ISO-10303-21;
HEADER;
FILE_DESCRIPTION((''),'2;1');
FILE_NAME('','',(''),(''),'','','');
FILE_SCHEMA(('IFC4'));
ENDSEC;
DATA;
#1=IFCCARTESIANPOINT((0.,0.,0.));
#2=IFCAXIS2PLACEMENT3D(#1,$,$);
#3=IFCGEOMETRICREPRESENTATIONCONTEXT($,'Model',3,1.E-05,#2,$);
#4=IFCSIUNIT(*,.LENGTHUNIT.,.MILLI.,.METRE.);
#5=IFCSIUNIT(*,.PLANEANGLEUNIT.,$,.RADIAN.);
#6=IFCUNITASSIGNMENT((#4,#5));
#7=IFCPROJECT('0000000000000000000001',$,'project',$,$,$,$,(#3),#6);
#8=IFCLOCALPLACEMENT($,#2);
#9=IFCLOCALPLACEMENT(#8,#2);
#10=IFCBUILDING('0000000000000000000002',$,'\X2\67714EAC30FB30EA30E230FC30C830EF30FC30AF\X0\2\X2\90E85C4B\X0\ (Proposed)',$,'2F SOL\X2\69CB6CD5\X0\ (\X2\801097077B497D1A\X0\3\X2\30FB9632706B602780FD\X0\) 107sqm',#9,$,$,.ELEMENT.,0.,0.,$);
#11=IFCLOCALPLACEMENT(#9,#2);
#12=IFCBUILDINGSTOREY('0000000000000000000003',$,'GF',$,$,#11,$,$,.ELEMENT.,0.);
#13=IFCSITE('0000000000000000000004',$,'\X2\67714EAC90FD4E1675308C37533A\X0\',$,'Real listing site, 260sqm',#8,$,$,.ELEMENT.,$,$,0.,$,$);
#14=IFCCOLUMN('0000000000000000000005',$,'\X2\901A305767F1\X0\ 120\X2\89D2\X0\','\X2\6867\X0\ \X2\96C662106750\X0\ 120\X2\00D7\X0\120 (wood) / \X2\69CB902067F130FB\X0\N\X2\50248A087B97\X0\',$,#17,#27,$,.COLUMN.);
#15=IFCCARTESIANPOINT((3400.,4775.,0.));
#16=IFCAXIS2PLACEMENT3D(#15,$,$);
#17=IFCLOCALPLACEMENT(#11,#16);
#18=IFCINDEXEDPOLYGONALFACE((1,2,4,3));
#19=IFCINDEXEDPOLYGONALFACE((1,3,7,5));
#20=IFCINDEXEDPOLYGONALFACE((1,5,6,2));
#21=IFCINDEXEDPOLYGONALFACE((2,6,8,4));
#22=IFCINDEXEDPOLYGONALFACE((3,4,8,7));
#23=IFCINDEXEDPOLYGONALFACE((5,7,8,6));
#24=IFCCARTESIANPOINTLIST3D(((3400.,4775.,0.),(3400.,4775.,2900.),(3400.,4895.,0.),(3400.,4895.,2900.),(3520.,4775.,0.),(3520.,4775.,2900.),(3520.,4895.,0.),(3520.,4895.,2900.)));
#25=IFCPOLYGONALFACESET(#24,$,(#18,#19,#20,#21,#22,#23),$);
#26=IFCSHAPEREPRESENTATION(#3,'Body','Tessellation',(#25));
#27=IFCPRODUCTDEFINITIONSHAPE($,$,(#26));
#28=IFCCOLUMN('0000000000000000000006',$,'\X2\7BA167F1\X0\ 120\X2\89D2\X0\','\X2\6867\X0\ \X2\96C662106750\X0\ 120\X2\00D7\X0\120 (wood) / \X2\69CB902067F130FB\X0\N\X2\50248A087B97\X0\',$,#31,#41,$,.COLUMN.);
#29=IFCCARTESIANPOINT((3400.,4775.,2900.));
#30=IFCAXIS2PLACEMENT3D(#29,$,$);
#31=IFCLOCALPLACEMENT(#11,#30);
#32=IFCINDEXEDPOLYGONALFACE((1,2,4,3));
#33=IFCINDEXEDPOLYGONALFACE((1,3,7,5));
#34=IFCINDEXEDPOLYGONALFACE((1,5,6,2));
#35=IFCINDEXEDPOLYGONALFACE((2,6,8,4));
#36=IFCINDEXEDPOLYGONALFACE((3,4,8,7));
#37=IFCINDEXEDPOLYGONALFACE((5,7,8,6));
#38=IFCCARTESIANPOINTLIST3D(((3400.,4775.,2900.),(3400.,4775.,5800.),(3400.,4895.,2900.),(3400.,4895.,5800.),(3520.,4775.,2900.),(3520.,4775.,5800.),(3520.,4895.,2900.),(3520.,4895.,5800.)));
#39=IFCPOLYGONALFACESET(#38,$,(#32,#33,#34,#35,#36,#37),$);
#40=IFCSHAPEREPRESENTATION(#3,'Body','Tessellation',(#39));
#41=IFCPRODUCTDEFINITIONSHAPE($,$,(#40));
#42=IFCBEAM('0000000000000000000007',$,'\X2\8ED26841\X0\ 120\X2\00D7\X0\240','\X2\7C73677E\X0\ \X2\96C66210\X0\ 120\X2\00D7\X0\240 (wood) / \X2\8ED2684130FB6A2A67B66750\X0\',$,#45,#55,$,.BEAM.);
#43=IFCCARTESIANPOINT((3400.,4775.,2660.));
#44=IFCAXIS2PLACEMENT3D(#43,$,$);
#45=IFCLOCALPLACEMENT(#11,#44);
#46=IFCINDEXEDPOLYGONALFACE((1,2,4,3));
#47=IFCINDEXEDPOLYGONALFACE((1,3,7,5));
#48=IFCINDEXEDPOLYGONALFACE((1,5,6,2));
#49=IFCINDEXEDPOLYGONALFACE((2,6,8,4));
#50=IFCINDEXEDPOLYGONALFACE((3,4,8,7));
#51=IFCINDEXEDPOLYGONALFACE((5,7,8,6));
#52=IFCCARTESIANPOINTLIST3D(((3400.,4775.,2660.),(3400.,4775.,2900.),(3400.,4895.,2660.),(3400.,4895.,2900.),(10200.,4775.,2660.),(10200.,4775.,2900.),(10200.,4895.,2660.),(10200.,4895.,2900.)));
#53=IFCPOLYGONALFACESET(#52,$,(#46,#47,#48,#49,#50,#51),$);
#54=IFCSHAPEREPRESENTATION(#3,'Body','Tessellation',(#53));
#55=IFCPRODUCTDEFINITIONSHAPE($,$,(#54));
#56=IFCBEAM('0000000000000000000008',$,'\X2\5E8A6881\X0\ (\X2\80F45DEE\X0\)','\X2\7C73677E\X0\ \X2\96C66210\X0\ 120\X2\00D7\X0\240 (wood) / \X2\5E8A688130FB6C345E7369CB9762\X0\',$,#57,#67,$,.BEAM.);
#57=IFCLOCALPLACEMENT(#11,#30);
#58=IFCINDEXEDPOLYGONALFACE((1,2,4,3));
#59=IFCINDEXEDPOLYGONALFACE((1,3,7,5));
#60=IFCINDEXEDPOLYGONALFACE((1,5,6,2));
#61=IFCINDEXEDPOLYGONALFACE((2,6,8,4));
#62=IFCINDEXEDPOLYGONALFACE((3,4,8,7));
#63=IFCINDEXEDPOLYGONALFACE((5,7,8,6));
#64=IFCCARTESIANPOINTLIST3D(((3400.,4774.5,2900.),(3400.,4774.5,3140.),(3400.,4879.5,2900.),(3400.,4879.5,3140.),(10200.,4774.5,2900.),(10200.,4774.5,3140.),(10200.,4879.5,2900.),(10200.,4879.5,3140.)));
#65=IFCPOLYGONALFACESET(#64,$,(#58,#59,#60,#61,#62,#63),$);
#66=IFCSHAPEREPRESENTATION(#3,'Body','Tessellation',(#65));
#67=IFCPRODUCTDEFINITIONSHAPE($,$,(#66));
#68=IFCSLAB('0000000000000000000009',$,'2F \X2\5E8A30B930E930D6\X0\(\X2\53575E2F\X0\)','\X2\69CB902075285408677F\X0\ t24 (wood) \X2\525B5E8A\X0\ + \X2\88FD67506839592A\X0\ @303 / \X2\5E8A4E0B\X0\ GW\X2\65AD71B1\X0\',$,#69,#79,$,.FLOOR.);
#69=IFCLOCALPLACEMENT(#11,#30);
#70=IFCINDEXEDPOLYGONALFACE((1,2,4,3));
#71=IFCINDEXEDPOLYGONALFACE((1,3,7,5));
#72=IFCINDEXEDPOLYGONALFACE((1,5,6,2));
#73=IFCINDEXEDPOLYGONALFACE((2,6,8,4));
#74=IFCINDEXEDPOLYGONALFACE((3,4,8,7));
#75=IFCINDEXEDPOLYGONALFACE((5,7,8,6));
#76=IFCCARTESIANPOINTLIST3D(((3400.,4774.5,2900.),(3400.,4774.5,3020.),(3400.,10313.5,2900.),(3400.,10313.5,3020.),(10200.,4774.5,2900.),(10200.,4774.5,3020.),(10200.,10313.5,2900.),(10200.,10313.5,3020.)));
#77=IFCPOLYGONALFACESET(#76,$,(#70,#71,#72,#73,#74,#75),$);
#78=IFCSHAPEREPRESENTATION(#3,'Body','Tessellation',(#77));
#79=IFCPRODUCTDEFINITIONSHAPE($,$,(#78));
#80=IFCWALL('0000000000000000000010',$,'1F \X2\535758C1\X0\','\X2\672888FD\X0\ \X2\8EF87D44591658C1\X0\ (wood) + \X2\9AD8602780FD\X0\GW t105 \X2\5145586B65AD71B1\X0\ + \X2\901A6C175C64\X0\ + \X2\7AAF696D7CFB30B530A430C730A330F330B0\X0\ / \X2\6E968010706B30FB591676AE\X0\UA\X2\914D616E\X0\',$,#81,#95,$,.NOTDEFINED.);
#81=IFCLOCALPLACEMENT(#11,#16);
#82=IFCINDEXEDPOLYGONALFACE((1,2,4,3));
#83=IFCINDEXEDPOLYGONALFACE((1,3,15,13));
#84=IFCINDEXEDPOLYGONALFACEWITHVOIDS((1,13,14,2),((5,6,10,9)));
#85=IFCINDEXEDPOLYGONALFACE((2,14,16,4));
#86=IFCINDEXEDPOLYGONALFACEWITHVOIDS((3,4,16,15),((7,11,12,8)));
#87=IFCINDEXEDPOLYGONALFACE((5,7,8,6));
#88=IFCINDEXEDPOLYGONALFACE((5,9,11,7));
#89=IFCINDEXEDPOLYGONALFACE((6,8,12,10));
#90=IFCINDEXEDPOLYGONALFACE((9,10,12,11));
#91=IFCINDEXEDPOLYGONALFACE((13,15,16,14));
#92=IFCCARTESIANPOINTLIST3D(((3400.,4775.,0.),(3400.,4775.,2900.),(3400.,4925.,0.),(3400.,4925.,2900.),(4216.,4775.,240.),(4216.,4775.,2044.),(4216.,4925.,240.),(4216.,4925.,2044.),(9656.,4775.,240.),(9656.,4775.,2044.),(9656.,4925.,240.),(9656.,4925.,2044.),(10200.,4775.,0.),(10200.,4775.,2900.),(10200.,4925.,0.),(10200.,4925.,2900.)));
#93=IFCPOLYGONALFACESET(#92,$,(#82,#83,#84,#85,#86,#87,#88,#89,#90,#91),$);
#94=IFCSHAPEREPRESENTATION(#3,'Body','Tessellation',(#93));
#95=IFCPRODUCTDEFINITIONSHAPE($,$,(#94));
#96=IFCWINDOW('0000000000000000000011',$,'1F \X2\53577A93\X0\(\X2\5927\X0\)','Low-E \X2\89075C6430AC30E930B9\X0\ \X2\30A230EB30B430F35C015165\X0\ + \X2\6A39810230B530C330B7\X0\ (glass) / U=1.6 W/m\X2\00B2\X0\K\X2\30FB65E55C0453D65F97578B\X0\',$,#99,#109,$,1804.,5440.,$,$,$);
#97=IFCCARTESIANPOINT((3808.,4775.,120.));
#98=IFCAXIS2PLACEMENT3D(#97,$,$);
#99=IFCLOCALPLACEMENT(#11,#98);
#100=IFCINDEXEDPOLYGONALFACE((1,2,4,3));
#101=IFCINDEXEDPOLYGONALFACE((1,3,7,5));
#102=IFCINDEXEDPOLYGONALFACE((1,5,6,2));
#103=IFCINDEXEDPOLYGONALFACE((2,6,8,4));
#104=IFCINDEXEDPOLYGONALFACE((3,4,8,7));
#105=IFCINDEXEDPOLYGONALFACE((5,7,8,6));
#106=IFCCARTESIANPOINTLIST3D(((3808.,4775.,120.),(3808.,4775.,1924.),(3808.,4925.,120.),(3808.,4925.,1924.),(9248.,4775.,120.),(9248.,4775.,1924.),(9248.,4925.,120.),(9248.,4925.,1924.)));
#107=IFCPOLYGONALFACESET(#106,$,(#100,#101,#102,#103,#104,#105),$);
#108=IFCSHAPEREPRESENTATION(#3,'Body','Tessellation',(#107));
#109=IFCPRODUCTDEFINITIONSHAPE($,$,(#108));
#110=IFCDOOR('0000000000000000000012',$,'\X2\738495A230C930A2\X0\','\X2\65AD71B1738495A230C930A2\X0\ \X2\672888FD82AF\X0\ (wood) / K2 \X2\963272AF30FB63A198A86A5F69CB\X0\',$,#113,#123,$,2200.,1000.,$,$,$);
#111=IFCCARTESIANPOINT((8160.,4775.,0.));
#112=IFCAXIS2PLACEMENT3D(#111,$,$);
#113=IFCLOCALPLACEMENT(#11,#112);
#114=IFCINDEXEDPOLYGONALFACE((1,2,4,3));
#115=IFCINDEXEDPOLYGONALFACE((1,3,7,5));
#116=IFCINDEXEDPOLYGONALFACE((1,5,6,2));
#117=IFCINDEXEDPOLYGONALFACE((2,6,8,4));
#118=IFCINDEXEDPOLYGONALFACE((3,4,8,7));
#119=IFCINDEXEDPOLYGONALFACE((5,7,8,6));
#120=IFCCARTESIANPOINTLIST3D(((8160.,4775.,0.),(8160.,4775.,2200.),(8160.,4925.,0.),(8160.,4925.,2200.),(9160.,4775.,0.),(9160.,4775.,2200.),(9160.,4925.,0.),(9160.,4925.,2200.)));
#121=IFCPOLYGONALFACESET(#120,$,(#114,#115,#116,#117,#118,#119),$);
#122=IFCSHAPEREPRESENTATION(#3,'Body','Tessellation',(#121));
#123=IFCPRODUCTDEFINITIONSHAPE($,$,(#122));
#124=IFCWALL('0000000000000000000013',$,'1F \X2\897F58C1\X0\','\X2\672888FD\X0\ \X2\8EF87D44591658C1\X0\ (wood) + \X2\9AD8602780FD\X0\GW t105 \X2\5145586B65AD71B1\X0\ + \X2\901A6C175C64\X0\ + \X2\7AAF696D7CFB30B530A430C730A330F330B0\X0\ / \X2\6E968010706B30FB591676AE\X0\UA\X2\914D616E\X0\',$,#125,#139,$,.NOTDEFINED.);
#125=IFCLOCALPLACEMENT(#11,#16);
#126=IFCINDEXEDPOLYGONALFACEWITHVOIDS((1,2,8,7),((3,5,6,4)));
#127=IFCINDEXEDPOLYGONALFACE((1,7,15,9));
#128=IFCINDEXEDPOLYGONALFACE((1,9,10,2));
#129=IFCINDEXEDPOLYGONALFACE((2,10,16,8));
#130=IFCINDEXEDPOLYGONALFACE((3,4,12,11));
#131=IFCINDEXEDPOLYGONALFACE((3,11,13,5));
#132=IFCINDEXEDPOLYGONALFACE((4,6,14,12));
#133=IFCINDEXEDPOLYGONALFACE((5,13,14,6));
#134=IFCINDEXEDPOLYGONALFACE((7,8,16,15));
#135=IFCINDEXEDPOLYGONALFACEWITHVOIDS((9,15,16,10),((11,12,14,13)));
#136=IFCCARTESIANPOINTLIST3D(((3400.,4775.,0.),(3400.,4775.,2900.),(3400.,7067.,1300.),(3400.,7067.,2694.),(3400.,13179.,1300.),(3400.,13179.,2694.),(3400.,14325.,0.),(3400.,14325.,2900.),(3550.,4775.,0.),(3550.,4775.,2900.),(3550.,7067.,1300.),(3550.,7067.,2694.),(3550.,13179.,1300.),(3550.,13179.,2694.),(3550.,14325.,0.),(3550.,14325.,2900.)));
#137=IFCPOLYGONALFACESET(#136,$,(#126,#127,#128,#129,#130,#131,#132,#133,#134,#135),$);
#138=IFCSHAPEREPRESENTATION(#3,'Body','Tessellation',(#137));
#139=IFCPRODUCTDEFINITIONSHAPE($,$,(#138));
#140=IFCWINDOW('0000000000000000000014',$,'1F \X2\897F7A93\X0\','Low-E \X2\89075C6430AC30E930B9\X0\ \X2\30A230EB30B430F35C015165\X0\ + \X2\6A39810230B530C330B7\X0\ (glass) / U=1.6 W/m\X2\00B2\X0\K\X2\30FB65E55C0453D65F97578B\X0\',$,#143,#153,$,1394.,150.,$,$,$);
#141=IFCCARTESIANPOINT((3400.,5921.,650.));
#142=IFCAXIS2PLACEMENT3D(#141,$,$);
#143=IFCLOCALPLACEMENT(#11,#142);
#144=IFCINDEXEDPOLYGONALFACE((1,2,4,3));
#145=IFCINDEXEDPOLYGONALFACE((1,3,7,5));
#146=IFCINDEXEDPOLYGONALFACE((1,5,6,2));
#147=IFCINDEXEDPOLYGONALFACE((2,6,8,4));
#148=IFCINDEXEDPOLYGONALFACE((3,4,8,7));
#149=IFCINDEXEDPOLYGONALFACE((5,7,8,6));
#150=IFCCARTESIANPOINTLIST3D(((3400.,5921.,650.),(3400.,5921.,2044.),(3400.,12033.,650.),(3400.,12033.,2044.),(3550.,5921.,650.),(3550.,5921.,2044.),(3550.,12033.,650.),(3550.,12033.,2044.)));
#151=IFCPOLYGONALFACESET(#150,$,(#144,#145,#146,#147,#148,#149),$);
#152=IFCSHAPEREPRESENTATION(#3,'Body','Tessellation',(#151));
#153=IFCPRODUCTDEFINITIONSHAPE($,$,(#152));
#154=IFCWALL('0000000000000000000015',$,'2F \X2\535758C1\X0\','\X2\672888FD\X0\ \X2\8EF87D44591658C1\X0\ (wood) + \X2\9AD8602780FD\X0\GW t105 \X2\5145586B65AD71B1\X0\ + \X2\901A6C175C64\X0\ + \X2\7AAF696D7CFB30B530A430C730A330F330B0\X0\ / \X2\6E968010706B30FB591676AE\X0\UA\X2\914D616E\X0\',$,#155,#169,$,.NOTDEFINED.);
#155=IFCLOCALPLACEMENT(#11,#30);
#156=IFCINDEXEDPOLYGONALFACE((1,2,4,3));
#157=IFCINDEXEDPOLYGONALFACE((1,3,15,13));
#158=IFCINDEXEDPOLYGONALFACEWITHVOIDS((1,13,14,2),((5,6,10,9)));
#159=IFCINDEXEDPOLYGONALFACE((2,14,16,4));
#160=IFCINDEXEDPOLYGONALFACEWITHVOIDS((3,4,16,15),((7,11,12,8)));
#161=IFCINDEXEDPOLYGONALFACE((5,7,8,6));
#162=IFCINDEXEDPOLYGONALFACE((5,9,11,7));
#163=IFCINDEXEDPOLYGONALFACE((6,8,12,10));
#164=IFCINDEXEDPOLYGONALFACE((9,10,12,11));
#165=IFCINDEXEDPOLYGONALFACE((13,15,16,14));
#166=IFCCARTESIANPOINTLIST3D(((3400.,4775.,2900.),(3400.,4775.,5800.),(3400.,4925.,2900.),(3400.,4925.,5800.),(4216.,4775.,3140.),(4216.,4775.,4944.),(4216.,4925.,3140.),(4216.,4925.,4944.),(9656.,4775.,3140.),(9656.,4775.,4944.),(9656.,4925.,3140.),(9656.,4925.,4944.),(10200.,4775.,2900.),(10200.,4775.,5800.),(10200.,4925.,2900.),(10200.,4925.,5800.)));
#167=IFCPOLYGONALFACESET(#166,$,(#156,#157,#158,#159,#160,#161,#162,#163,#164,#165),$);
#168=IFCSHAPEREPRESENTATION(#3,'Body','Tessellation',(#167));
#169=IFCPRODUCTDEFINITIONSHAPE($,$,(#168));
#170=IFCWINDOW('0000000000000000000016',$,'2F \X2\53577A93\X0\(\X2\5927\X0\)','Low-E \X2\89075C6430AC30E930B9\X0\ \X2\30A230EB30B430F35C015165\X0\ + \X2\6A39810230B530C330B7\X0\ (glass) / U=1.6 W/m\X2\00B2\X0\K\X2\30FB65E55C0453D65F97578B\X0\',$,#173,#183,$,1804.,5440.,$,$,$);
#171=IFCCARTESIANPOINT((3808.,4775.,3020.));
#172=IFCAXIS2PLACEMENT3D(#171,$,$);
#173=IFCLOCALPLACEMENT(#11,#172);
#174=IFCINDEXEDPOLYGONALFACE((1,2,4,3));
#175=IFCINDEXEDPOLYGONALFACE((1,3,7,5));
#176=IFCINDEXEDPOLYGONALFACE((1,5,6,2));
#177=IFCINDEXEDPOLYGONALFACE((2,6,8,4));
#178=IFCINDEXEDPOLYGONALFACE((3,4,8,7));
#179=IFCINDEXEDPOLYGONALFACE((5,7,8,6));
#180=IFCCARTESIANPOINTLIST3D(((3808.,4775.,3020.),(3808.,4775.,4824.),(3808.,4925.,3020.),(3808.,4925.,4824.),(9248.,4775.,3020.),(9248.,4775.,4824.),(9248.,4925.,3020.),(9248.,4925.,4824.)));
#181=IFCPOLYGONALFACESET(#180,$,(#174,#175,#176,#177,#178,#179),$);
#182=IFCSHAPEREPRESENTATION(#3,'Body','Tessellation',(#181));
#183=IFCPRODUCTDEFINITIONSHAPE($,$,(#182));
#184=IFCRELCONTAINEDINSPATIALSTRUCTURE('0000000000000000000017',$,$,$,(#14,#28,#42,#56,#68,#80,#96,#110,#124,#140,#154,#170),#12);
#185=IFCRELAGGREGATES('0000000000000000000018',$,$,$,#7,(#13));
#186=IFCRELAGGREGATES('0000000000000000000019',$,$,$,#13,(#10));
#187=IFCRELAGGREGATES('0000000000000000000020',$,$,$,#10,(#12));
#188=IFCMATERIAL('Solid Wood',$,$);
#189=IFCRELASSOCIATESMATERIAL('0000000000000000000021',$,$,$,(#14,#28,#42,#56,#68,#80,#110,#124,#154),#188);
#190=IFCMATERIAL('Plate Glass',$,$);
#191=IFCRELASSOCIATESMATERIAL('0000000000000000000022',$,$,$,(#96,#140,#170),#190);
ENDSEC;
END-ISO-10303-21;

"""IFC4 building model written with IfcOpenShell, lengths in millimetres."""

from ifc_helpers import new_model, si_unit, frame, frame_2d, origin, place, context, project, spatial, rectangle, extrude, material, element, fill, save


model = new_model("IFC4")

# Units and contexts
model_context = context("Model", 3, precision=1e-05, world=origin())
ifc_project = project(units=[si_unit("LENGTHUNIT", "METRE", prefix="MILLI"), si_unit("PLANEANGLEUNIT", "RADIAN")], contexts=[model_context])

# Site, building, storey
site_placement = place(None, origin())
site = spatial("IfcSite", under=ifc_project, at=site_placement, Name="東京都世田谷区", ObjectType="Real listing site, 260sqm", CompositionType="ELEMENT", RefElevation=0.0)
building_placement = place(site_placement, origin())
building = spatial("IfcBuilding", under=site, at=building_placement, Name="東京・リモートワーク2部屋 (Proposed)", ObjectType="2F SOL構法 (耐震等級3・防火性能) 107sqm", CompositionType="ELEMENT", ElevationOfRefHeight=0.0, ElevationOfTerrain=0.0)
storey_placement = place(building_placement, origin())
storey = spatial("IfcBuildingStorey", under=building, at=storey_placement, Name="GF", CompositionType="ELEMENT", Elevation=0.0)

# Columns
ifc_material_1 = material(Name="Solid Wood")
column_1_placement = place(storey_placement, frame((3400.0, 4775.0, 0.0)))
element("IfcColumn", 1, at=column_1_placement, inside=storey, material=ifc_material_1, Name="通し柱 120角", Description="桧 集成材 120×120 (wood) / 構造柱・N値計算", PredefinedType="COLUMN", context=model_context, shape_type="SweptSolid", body=[
    extrude(rectangle(XDim=120.0, YDim=120.0, at=frame_2d((60.0, 60.0))), frame((3400.0, 4775.0, 0.0)), (0.0, 0.0, 1.0), 2900.0),
])
column_2_placement = place(storey_placement, frame((3400.0, 4775.0, 2900.0)))
element("IfcColumn", 2, at=column_2_placement, inside=storey, material=ifc_material_1, Name="管柱 120角", Description="桧 集成材 120×120 (wood) / 構造柱・N値計算", PredefinedType="COLUMN", context=model_context, shape_type="SweptSolid", body=[
    extrude(rectangle(XDim=120.0, YDim=120.0, at=frame_2d((60.0, 60.0))), frame((3400.0, 4775.0, 2900.0)), (0.0, 0.0, 1.0), 2900.0),
])

# Beams
beam_1_placement = place(storey_placement, frame((3400.0, 4775.0, 2660.0)))
element("IfcBeam", 3, at=beam_1_placement, inside=storey, material=ifc_material_1, Name="軒桁 120×240", Description="米松 集成 120×240 (wood) / 軒桁・横架材", PredefinedType="BEAM", context=model_context, shape_type="SweptSolid", body=[
    extrude(rectangle(XDim=6800.0, YDim=120.0, at=frame_2d((3400.0, 60.0))), frame((3400.0, 4775.0, 2660.0)), (0.0, 0.0, 1.0), 240.0),
])
beam_2_placement = place(storey_placement, frame((3400.0, 4775.0, 2900.0)))
element("IfcBeam", 4, at=beam_2_placement, inside=storey, material=ifc_material_1, Name="床梁 (胴差)", Description="米松 集成 120×240 (wood) / 床梁・水平構面", PredefinedType="BEAM", context=model_context, shape_type="SweptSolid", body=[
    extrude(rectangle(XDim=6800.0, YDim=105.0, at=frame_2d((3400.0, 52.0))), frame((3400.0, 4775.0, 2900.0)), (0.0, 0.0, 1.0), 240.0),
])

# Slab
slab_1_placement = place(storey_placement, frame((3400.0, 4775.0, 2900.0)))
element("IfcSlab", 5, at=slab_1_placement, inside=storey, material=ifc_material_1, Name="2F 床スラブ(南帯)", Description="構造用合板 t24 (wood) 剛床 + 製材根太 @303 / 床下 GW断熱", PredefinedType="FLOOR", context=model_context, shape_type="SweptSolid", body=[
    extrude(rectangle(XDim=6800.0, YDim=5539.0, at=frame_2d((3400.0, 2769.0))), frame((3400.0, 4775.0, 2900.0)), (0.0, 0.0, 1.0), 120.0),
])

# Wall, openings, window, door
wall_1_placement = place(storey_placement, frame((3400.0, 4775.0, 0.0)))
wall_1 = element("IfcWall", 6, at=wall_1_placement, inside=storey, material=ifc_material_1, Name="1F 南壁", Description="木製 軸組外壁 (wood) + 高性能GW t105 充填断熱 + 通気層 + 窯業系サイディング / 準耐火・外皮UA配慮", PredefinedType="NOTDEFINED", context=model_context, shape_type="SweptSolid", body=[
    extrude(rectangle(XDim=6800.0, YDim=150.0, at=frame_2d((3400.0, 75.0))), frame((3400.0, 4775.0, 0.0)), (0.0, 0.0, 1.0), 2900.0),
])
opening_1_placement = place(storey_placement, frame((3808.0, 4775.0, 120.0)))
opening_1 = element("IfcOpeningElement", 7, at=opening_1_placement, cuts=wall_1, PredefinedType="NOTDEFINED", context=model_context, shape_type="SweptSolid", body=[
    extrude(rectangle(XDim=5440.0, YDim=150.0, at=frame_2d((2720.0, 75.0))), frame((3808.0, 4775.0, 120.0)), (0.0, 0.0, 1.0), 1804.0),
])
opening_2_placement = place(storey_placement, frame((8160.0, 4775.0, 0.0)))
opening_2 = element("IfcOpeningElement", 8, at=opening_2_placement, cuts=wall_1, PredefinedType="NOTDEFINED", context=model_context, shape_type="SweptSolid", body=[
    extrude(rectangle(XDim=1000.0, YDim=150.0, at=frame_2d((500.0, 75.0))), frame((8160.0, 4775.0, 0.0)), (0.0, 0.0, 1.0), 2200.0),
])
ifc_material_2 = material(Name="Plate Glass")
window_1_placement = place(storey_placement, frame((3808.0, 4775.0, 120.0)))
window_1 = element("IfcWindow", 9, at=window_1_placement, inside=storey, material=ifc_material_2, Name="1F 南窓(大)", Description="Low-E 複層ガラス アルゴン封入 + 樹脂サッシ (glass) / U=1.6 W/m²K・日射取得型", OverallHeight=1804.0, OverallWidth=5440.0, context=model_context, shape_type="SweptSolid", body=[
    extrude(rectangle(XDim=5440.0, YDim=150.0, at=frame_2d((2720.0, 75.0))), frame((3808.0, 4775.0, 120.0)), (0.0, 0.0, 1.0), 1804.0),
])
fill(opening_1, window_1)
door_placement = place(storey_placement, frame((8160.0, 4775.0, 0.0)))
door = element("IfcDoor", 10, at=door_placement, inside=storey, material=ifc_material_1, Name="玄関ドア", Description="断熱玄関ドア 木製芯 (wood) / K2 防犯・採風機構", OverallHeight=2200.0, OverallWidth=1000.0, context=model_context, shape_type="SweptSolid", body=[
    extrude(rectangle(XDim=1000.0, YDim=150.0, at=frame_2d((500.0, 75.0))), frame((8160.0, 4775.0, 0.0)), (0.0, 0.0, 1.0), 2200.0),
])
fill(opening_2, door)

# Walls, openings, windows
wall_2_placement = place(storey_placement, frame((3400.0, 4775.0, 0.0)))
wall_2 = element("IfcWall", 11, at=wall_2_placement, inside=storey, material=ifc_material_1, Name="1F 西壁", Description="木製 軸組外壁 (wood) + 高性能GW t105 充填断熱 + 通気層 + 窯業系サイディング / 準耐火・外皮UA配慮", PredefinedType="NOTDEFINED", context=model_context, shape_type="SweptSolid", body=[
    extrude(rectangle(XDim=150.0, YDim=9550.0, at=frame_2d((75.0, 4775.0))), frame((3400.0, 4775.0, 0.0)), (0.0, 0.0, 1.0), 2900.0),
])
opening_3_placement = place(storey_placement, frame((3400.0, 5921.0, 650.0)))
opening_3 = element("IfcOpeningElement", 12, at=opening_3_placement, cuts=wall_2, PredefinedType="NOTDEFINED", context=model_context, shape_type="SweptSolid", body=[
    extrude(rectangle(XDim=150.0, YDim=6112.0, at=frame_2d((75.0, 3056.0))), frame((3400.0, 5921.0, 650.0)), (0.0, 0.0, 1.0), 1394.0),
])
window_2_placement = place(storey_placement, frame((3400.0, 5921.0, 650.0)))
window_2 = element("IfcWindow", 13, at=window_2_placement, inside=storey, material=ifc_material_2, Name="1F 西窓", Description="Low-E 複層ガラス アルゴン封入 + 樹脂サッシ (glass) / U=1.6 W/m²K・日射取得型", OverallHeight=1394.0, OverallWidth=150.0, context=model_context, shape_type="SweptSolid", body=[
    extrude(rectangle(XDim=150.0, YDim=6112.0, at=frame_2d((75.0, 3056.0))), frame((3400.0, 5921.0, 650.0)), (0.0, 0.0, 1.0), 1394.0),
])
fill(opening_3, window_2)
wall_3_placement = place(storey_placement, frame((3400.0, 4775.0, 2900.0)))
wall_3 = element("IfcWall", 14, at=wall_3_placement, inside=storey, material=ifc_material_1, Name="2F 南壁", Description="木製 軸組外壁 (wood) + 高性能GW t105 充填断熱 + 通気層 + 窯業系サイディング / 準耐火・外皮UA配慮", PredefinedType="NOTDEFINED", context=model_context, shape_type="SweptSolid", body=[
    extrude(rectangle(XDim=6800.0, YDim=150.0, at=frame_2d((3400.0, 75.0))), frame((3400.0, 4775.0, 2900.0)), (0.0, 0.0, 1.0), 2900.0),
])
opening_4_placement = place(storey_placement, frame((3808.0, 4775.0, 3020.0)))
opening_4 = element("IfcOpeningElement", 15, at=opening_4_placement, cuts=wall_3, PredefinedType="NOTDEFINED", context=model_context, shape_type="SweptSolid", body=[
    extrude(rectangle(XDim=5440.0, YDim=150.0, at=frame_2d((2720.0, 75.0))), frame((3808.0, 4775.0, 3020.0)), (0.0, 0.0, 1.0), 1804.0),
])
window_3_placement = place(storey_placement, frame((3808.0, 4775.0, 3020.0)))
window_3 = element("IfcWindow", 16, at=window_3_placement, inside=storey, material=ifc_material_2, Name="2F 南窓(大)", Description="Low-E 複層ガラス アルゴン封入 + 樹脂サッシ (glass) / U=1.6 W/m²K・日射取得型", OverallHeight=1804.0, OverallWidth=5440.0, context=model_context, shape_type="SweptSolid", body=[
    extrude(rectangle(XDim=5440.0, YDim=150.0, at=frame_2d((2720.0, 75.0))), frame((3808.0, 4775.0, 3020.0)), (0.0, 0.0, 1.0), 1804.0),
])
fill(opening_4, window_3)

save(model, "model.ifc")
